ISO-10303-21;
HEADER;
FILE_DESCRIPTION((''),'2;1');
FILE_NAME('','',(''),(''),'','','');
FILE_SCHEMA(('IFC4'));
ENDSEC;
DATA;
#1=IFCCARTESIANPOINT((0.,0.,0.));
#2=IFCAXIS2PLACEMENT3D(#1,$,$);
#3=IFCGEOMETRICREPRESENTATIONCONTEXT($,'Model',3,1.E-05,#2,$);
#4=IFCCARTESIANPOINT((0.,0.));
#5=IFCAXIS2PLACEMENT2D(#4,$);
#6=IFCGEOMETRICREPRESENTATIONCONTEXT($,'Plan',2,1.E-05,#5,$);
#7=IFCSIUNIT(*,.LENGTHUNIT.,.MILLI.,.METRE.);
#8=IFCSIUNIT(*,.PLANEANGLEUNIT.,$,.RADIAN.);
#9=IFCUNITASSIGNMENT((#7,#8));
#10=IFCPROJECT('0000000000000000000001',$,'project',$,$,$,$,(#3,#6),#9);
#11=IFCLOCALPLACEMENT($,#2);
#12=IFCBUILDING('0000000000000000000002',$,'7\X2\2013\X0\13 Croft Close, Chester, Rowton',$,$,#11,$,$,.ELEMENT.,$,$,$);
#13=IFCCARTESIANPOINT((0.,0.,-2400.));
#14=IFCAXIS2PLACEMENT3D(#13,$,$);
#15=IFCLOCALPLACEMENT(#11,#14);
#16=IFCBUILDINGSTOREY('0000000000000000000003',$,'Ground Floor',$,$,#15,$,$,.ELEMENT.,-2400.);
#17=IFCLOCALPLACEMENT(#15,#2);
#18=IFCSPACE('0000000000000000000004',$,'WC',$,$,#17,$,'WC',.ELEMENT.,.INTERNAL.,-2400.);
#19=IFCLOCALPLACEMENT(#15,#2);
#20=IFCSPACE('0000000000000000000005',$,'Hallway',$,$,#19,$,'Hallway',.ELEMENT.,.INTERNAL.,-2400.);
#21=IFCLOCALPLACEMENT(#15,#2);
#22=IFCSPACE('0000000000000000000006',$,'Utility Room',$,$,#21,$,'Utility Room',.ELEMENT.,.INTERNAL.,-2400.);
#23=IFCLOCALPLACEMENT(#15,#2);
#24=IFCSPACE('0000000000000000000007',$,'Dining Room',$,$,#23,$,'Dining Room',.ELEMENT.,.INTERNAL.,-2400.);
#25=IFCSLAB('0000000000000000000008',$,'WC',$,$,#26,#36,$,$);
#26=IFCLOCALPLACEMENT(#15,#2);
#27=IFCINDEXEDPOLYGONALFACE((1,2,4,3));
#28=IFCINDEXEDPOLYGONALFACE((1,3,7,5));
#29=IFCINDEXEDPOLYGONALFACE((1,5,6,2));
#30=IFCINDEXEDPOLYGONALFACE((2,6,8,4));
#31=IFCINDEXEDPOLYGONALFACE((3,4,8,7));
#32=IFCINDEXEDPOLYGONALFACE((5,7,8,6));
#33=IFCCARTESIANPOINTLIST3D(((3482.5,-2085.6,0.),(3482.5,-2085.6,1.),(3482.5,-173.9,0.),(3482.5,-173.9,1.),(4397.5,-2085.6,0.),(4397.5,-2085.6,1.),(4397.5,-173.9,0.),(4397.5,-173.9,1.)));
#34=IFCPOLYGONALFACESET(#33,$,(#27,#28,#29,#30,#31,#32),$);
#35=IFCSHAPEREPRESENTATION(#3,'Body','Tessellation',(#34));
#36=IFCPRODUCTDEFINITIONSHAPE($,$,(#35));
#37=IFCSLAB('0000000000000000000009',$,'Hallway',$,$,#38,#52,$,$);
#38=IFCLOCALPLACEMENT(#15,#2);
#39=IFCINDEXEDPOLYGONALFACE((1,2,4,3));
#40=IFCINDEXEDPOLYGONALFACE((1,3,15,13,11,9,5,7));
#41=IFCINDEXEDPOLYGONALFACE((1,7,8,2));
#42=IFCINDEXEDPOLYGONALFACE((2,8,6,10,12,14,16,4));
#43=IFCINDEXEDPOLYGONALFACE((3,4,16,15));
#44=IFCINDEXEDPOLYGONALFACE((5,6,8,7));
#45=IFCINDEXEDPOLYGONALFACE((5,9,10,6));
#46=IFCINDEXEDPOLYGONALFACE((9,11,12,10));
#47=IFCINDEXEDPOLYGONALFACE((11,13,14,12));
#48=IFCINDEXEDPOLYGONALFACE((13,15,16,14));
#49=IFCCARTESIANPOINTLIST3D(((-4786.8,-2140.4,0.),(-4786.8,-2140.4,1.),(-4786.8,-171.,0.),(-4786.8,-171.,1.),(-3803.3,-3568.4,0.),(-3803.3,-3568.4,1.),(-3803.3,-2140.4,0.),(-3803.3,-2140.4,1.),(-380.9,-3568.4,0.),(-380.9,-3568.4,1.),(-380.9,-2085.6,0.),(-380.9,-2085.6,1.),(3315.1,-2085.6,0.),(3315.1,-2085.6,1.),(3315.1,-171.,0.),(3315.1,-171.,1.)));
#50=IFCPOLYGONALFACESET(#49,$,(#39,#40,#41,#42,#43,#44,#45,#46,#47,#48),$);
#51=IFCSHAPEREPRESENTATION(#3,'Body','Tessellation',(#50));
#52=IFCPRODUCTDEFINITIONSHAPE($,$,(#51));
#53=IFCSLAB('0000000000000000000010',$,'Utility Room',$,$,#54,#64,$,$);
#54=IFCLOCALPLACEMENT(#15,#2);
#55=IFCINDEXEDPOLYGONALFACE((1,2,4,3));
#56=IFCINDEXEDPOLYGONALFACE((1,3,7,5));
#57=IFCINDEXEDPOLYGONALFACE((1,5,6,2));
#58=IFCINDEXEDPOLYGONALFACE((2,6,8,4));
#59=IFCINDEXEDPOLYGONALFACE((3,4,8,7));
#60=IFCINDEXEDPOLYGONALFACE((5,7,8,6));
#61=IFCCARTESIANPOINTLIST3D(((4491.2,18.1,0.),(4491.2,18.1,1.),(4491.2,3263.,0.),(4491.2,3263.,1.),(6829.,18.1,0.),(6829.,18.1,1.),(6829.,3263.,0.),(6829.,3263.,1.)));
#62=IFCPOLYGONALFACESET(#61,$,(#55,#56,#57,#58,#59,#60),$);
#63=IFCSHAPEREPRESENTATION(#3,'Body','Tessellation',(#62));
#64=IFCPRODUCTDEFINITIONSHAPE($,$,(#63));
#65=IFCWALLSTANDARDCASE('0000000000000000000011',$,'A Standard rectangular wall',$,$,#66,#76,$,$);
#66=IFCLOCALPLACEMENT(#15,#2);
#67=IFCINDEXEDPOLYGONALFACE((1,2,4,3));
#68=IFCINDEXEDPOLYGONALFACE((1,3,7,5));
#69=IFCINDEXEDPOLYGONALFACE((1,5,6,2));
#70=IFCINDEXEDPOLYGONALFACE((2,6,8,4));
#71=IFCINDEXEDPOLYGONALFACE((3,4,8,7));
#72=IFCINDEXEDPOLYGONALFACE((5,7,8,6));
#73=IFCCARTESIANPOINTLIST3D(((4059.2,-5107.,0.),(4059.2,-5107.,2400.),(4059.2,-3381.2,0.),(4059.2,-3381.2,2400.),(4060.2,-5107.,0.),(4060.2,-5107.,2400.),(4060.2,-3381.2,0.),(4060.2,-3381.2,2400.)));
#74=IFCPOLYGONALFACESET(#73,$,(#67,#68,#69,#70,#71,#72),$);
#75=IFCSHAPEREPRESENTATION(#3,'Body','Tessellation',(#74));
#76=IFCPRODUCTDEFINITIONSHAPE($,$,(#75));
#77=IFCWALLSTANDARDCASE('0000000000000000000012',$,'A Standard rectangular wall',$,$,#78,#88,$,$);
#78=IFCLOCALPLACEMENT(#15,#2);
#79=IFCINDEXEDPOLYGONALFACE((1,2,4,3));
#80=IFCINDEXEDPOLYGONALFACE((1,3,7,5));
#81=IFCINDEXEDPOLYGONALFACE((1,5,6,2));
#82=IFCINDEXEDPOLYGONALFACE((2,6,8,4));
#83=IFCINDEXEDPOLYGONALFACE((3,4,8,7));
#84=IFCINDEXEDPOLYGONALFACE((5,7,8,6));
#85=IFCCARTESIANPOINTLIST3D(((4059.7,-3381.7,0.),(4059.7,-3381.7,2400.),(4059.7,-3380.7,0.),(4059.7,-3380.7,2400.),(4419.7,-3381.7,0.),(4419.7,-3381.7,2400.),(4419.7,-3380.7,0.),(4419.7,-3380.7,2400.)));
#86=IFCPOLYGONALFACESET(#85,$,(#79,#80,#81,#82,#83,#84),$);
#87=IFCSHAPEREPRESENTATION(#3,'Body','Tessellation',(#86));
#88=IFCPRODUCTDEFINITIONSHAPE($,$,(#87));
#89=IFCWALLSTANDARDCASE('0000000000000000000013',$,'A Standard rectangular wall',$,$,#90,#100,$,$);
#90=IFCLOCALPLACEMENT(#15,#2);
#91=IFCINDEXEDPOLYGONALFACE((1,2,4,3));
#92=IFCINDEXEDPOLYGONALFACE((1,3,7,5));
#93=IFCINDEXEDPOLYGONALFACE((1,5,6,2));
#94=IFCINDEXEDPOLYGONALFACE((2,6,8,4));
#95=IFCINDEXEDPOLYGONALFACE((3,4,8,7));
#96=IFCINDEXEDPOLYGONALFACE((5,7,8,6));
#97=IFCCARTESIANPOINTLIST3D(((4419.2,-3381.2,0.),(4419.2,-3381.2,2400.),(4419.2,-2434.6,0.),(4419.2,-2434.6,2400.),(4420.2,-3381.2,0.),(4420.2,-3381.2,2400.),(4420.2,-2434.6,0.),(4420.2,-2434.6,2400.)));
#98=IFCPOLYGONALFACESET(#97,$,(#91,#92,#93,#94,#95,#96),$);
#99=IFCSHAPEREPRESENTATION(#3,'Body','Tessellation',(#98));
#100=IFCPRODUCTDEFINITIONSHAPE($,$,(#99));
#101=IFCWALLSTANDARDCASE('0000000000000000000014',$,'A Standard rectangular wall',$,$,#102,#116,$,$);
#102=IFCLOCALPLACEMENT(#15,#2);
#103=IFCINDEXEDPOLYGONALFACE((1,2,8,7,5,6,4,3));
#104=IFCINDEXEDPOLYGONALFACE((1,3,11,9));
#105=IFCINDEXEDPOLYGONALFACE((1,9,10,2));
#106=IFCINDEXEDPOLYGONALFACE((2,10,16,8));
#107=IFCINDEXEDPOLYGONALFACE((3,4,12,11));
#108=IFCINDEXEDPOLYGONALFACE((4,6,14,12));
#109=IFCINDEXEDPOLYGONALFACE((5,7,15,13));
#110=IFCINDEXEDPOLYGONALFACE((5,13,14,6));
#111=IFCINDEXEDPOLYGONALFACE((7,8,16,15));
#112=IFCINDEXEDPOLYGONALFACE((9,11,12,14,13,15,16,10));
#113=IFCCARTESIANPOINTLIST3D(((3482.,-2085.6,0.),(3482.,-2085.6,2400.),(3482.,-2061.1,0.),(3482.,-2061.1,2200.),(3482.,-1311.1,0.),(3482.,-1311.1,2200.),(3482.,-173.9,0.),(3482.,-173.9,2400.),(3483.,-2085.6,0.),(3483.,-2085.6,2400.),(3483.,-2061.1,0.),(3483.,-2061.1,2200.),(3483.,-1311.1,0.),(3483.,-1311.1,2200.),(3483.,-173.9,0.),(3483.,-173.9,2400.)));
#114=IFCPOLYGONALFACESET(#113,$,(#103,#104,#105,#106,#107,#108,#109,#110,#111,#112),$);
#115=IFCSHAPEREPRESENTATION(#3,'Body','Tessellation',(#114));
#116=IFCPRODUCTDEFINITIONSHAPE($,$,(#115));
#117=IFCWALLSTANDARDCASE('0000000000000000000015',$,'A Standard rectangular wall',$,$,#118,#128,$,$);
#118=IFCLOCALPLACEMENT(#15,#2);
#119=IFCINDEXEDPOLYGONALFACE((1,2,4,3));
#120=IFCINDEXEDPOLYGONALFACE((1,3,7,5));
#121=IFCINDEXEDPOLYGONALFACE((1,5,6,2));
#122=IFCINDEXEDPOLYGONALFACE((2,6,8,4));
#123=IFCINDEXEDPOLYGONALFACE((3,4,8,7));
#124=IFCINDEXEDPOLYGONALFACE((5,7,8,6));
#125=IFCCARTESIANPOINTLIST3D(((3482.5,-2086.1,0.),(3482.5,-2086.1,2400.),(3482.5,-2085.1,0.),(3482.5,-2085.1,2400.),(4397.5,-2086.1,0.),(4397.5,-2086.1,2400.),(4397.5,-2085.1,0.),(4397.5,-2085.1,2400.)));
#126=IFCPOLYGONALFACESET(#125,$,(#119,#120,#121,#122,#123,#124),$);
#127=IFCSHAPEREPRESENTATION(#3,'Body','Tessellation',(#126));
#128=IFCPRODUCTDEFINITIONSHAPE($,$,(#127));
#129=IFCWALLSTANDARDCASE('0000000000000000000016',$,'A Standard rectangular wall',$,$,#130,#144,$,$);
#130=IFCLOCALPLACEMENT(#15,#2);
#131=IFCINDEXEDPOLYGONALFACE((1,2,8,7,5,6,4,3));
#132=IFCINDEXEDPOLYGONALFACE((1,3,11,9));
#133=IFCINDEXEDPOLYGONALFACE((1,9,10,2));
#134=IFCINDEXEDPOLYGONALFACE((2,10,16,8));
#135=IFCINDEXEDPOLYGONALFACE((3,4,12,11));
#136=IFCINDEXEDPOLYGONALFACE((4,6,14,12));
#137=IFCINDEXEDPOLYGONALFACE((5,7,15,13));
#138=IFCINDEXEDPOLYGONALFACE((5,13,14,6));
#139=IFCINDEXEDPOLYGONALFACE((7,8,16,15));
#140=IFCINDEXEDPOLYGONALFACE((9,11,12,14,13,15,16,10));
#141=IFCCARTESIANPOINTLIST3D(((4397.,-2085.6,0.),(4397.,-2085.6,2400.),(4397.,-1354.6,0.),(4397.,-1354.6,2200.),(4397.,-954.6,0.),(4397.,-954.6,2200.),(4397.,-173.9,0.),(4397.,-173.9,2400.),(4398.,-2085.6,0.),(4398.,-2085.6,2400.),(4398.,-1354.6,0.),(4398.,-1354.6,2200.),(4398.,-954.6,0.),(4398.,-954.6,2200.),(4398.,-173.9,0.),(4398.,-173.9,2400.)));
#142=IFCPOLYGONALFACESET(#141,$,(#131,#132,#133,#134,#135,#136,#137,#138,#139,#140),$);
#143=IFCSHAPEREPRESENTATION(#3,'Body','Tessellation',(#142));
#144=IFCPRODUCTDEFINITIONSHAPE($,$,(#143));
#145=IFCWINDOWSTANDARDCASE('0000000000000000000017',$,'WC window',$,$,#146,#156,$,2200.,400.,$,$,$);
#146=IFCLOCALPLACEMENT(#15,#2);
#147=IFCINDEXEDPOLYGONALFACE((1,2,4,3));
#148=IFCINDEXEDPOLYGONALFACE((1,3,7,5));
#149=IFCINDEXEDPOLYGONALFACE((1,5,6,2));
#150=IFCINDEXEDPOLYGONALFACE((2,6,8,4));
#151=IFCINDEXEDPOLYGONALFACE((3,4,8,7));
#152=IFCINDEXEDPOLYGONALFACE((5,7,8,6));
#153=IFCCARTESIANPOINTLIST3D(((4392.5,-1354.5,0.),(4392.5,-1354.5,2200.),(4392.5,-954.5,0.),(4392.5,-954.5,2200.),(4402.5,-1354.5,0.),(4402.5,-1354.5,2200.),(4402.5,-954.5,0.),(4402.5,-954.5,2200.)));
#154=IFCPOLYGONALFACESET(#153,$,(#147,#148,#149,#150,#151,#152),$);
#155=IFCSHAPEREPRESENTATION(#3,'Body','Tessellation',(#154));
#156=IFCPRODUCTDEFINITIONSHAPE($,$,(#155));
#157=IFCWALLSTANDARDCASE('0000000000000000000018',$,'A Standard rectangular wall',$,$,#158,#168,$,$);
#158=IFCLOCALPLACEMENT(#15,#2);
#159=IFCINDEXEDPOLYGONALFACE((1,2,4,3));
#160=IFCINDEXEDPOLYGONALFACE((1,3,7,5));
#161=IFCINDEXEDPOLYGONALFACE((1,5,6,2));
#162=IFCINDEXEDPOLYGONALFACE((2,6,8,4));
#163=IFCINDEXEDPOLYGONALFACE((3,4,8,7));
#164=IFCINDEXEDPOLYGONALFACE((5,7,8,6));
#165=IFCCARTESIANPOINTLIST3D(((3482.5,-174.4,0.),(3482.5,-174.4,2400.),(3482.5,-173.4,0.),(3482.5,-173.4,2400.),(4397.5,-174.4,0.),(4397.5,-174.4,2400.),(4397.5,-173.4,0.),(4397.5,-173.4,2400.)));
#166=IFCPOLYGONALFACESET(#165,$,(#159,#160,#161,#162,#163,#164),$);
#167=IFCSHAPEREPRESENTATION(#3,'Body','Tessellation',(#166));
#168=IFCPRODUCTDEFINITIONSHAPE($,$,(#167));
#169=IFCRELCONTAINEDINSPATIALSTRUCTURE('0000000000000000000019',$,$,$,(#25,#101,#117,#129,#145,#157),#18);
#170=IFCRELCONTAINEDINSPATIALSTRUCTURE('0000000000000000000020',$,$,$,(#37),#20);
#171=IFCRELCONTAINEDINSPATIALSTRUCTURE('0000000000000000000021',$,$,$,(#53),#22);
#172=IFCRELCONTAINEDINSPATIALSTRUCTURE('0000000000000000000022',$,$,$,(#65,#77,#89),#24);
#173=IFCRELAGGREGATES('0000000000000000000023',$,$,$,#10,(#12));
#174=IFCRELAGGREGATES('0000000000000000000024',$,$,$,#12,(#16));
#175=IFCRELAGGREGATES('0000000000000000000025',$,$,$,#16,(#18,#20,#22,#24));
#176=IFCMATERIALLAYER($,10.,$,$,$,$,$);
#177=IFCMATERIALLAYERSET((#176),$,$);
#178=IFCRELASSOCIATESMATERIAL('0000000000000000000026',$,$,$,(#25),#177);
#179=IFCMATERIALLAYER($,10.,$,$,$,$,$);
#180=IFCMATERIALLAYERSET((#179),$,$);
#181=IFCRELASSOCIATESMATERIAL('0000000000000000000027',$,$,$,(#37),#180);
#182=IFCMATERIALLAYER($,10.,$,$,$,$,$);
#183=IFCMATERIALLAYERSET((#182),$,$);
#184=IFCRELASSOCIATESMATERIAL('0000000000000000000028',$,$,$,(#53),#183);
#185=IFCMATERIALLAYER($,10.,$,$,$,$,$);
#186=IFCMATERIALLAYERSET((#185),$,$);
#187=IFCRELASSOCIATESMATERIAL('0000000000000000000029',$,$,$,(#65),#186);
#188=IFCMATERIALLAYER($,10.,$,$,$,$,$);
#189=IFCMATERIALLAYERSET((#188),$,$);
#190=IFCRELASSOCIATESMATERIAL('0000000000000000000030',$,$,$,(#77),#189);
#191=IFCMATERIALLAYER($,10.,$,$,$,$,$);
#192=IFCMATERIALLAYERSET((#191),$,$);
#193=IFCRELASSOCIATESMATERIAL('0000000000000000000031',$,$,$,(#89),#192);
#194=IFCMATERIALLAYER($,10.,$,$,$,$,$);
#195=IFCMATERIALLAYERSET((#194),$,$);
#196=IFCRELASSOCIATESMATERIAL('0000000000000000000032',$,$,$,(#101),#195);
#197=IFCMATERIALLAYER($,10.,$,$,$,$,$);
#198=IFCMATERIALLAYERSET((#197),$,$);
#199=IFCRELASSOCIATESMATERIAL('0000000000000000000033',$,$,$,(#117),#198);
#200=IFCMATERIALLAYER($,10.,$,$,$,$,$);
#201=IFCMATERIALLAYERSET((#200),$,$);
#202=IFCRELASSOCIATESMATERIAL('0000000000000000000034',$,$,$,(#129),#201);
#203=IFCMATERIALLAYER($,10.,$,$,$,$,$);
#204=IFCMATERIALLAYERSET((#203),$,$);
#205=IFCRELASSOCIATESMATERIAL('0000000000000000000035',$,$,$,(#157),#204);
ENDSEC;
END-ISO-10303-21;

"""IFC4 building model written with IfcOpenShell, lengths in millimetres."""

from ifc_helpers import new_model, si_unit, frame, origin, origin_2d, place, context, project, spatial, polyline, rectangle, outline, extrude, layer, layer_set, layer_usage, element, fill, save


model = new_model("IFC4")

# Units and contexts
model_context = context("Model", 3, precision=1e-05, world=origin())
plan_context = context("Plan", 2, precision=1e-05, world=origin_2d())
ifc_project = project(units=[si_unit("LENGTHUNIT", "METRE", prefix="MILLI"), si_unit("PLANEANGLEUNIT", "RADIAN")], contexts=[model_context, plan_context])

# Building, storey, space
building_placement = place(None, origin())
building = spatial("IfcBuilding", under=ifc_project, at=building_placement, Name="7–13 Croft Close, Chester, Rowton", CompositionType="ELEMENT")
storey_placement = place(building_placement, frame((0.0, 0.0, -2400.0)))
storey = spatial("IfcBuildingStorey", under=building, at=storey_placement, Name="Ground Floor", CompositionType="ELEMENT", Elevation=-2400.0)
space_1_placement = place(storey_placement, origin())
space_1 = spatial("IfcSpace", under=storey, at=space_1_placement, Name="WC", LongName="WC", CompositionType="ELEMENT", PredefinedType="INTERNAL", ElevationWithFlooring=-2400.0)

# Slab
ifc_layer_1 = layer(None, 10.0)
ifc_layer_set_1 = layer_set([ifc_layer_1])
ifc_layer_usage_1 = layer_usage(ifc_layer_set_1, "AXIS2", "NEGATIVE", 150.0)
slab_1_placement = place(storey_placement, origin())
element("IfcSlab", 1, at=slab_1_placement, inside=space_1, material=ifc_layer_usage_1, Name="WC", context=model_context, shape_type="SweptSolid", body=[
    extrude(outline(polyline([(3482.5, -173.9), (3482.5, -2085.6), (4397.5, -2085.6), (4397.5, -173.9), (3482.5, -173.9)])), origin(), (0.0, 0.0, 1.0), 1.0),
])

# Shared definitions
space_2_placement = place(storey_placement, origin())
space_2 = spatial("IfcSpace", under=storey, at=space_2_placement, Name="Hallway", LongName="Hallway", CompositionType="ELEMENT", PredefinedType="INTERNAL", ElevationWithFlooring=-2400.0)

# Slab
ifc_layer_2 = layer(None, 10.0)
ifc_layer_set_2 = layer_set([ifc_layer_2])
ifc_layer_usage_2 = layer_usage(ifc_layer_set_2, "AXIS2", "NEGATIVE", 150.0)
slab_2_placement = place(storey_placement, origin())
element("IfcSlab", 2, at=slab_2_placement, inside=space_2, material=ifc_layer_usage_2, Name="Hallway", context=model_context, shape_type="SweptSolid", body=[
    extrude(outline(polyline([(3315.1, -171.0), (-4786.8, -171.0), (-4786.8, -2140.4), (-3803.3, -2140.4), (-3803.3, -3568.4), (-380.9, -3568.4), (-380.9, -2085.6), (3315.1, -2085.6), (3315.1, -171.0)])), origin(), (0.0, 0.0, 1.0), 1.0),
])

# Shared definitions
space_3_placement = place(storey_placement, origin())
space_3 = spatial("IfcSpace", under=storey, at=space_3_placement, Name="Utility Room", LongName="Utility Room", CompositionType="ELEMENT", PredefinedType="INTERNAL", ElevationWithFlooring=-2400.0)

# Slab
ifc_layer_3 = layer(None, 10.0)
ifc_layer_set_3 = layer_set([ifc_layer_3])
ifc_layer_usage_3 = layer_usage(ifc_layer_set_3, "AXIS2", "NEGATIVE", 150.0)
slab_3_placement = place(storey_placement, origin())
element("IfcSlab", 3, at=slab_3_placement, inside=space_3, material=ifc_layer_usage_3, Name="Utility Room", context=model_context, shape_type="SweptSolid", body=[
    extrude(outline(polyline([(4491.2, 18.1), (6829.0, 18.1), (6829.0, 3263.0), (4491.2, 3263.0), (4491.2, 18.1)])), origin(), (0.0, 0.0, 1.0), 1.0),
])

# Shared definitions
space_4_placement = place(storey_placement, origin())
space_4 = spatial("IfcSpace", under=storey, at=space_4_placement, Name="Dining Room", LongName="Dining Room", CompositionType="ELEMENT", PredefinedType="INTERNAL", ElevationWithFlooring=-2400.0)

# Walls
ifc_layer_4 = layer(None, 10.0)
ifc_layer_set_4 = layer_set([ifc_layer_4])
ifc_layer_usage_4 = layer_usage(ifc_layer_set_4, "AXIS2", "NEGATIVE", 150.0)
wall_1_placement = place(storey_placement, origin())
element("IfcWallStandardCase", 4, at=wall_1_placement, inside=space_4, material=ifc_layer_usage_4, Name="A Standard rectangular wall", context=model_context, shape_type="SweptSolid", body=[
    extrude(rectangle(XDim=1.0, YDim=1725.8, at=origin_2d()), frame((4059.7, -4244.1, 0.0), x_axis=(-1.0, 0.0, 0.0)), (0.0, 0.0, 1.0), 2400.0),
])
ifc_layer_5 = layer(None, 10.0)
ifc_layer_set_5 = layer_set([ifc_layer_5])
ifc_layer_usage_5 = layer_usage(ifc_layer_set_5, "AXIS2", "NEGATIVE", 150.0)
wall_2_placement = place(storey_placement, origin())
element("IfcWallStandardCase", 5, at=wall_2_placement, inside=space_4, material=ifc_layer_usage_5, Name="A Standard rectangular wall", context=model_context, shape_type="SweptSolid", body=[
    extrude(rectangle(XDim=1.0, YDim=360.0, at=origin_2d()), frame((4239.7, -3381.2, 0.0), x_axis=(0.0, 1.0, 0.0)), (0.0, 0.0, 1.0), 2400.0),
])
ifc_layer_6 = layer(None, 10.0)
ifc_layer_set_6 = layer_set([ifc_layer_6])
ifc_layer_usage_6 = layer_usage(ifc_layer_set_6, "AXIS2", "NEGATIVE", 150.0)
wall_3_placement = place(storey_placement, origin())
element("IfcWallStandardCase", 6, at=wall_3_placement, inside=space_4, material=ifc_layer_usage_6, Name="A Standard rectangular wall", context=model_context, shape_type="SweptSolid", body=[
    extrude(rectangle(XDim=1.0, YDim=946.6, at=origin_2d()), frame((4419.7, -2907.9, 0.0), x_axis=(-1.0, 0.0, 0.0)), (0.0, 0.0, 1.0), 2400.0),
])

# Wall, opening
ifc_layer_7 = layer(None, 10.0)
ifc_layer_set_7 = layer_set([ifc_layer_7])
ifc_layer_usage_7 = layer_usage(ifc_layer_set_7, "AXIS2", "NEGATIVE", 150.0)
wall_4_placement = place(storey_placement, origin())
wall_4 = element("IfcWallStandardCase", 7, at=wall_4_placement, inside=space_1, material=ifc_layer_usage_7, Name="A Standard rectangular wall", context=model_context, shape_type="SweptSolid", body=[
    extrude(rectangle(XDim=1.0, YDim=1911.7, at=origin_2d()), frame((3482.5, -1129.7, 0.0), x_axis=(1.0, 0.0, 0.0)), (0.0, 0.0, 1.0), 2400.0),
])
opening_1_placement = place(storey_placement, origin())
element("IfcOpeningElement", 8, at=opening_1_placement, cuts=wall_4, context=model_context, shape_type="SweptSolid", body=[
    extrude(rectangle(XDim=10.0, YDim=750.0, at=origin_2d()), frame((3482.5, -1686.1, 0.0), x_axis=(-1.0, 0.0, 0.0)), (0.0, 0.0, 1.0), 2200.0),
])

# Wall
ifc_layer_8 = layer(None, 10.0)
ifc_layer_set_8 = layer_set([ifc_layer_8])
ifc_layer_usage_8 = layer_usage(ifc_layer_set_8, "AXIS2", "NEGATIVE", 150.0)
wall_5_placement = place(storey_placement, origin())
element("IfcWallStandardCase", 9, at=wall_5_placement, inside=space_1, material=ifc_layer_usage_8, Name="A Standard rectangular wall", context=model_context, shape_type="SweptSolid", body=[
    extrude(rectangle(XDim=1.0, YDim=915.0, at=origin_2d()), frame((3940.0, -2085.6, 0.0), x_axis=(0.0, 1.0, 0.0)), (0.0, 0.0, 1.0), 2400.0),
])

# Wall, opening, window
ifc_layer_9 = layer(None, 10.0)
ifc_layer_set_9 = layer_set([ifc_layer_9])
ifc_layer_usage_9 = layer_usage(ifc_layer_set_9, "AXIS2", "NEGATIVE", 150.0)
wall_6_placement = place(storey_placement, origin())
wall_6 = element("IfcWallStandardCase", 10, at=wall_6_placement, inside=space_1, material=ifc_layer_usage_9, Name="A Standard rectangular wall", context=model_context, shape_type="SweptSolid", body=[
    extrude(rectangle(XDim=1.0, YDim=1911.7, at=origin_2d()), frame((4397.5, -1129.7, 0.0), x_axis=(-1.0, 0.0, 0.0)), (0.0, 0.0, 1.0), 2400.0),
])
opening_2_placement = place(storey_placement, origin())
opening_2 = element("IfcOpeningElement", 11, at=opening_2_placement, cuts=wall_6, context=model_context, shape_type="SweptSolid", body=[
    extrude(rectangle(XDim=10.0, YDim=400.0, at=origin_2d()), frame((4397.5, -1154.6, 0.0), x_axis=(-1.0, 0.0, 0.0)), (0.0, 0.0, 1.0), 2200.0),
])
window_1_placement = place(storey_placement, frame((0.0, 0.1, 0.0)))
window_1 = element("IfcWindowStandardCase", 12, at=window_1_placement, inside=space_1, Name="WC window", OverallHeight=2200.0, OverallWidth=400.0, context=model_context, shape_type="SweptSolid", body=[
    extrude(rectangle(XDim=10.0, YDim=400.0, at=origin_2d()), frame((4397.5, -1154.6, 0.0), x_axis=(-1.0, 0.0, 0.0)), (0.0, 0.0, 1.0), 2200.0),
])
fill(opening_2, window_1)

# Wall
ifc_layer_10 = layer(None, 10.0)
ifc_layer_set_10 = layer_set([ifc_layer_10])
ifc_layer_usage_10 = layer_usage(ifc_layer_set_10, "AXIS2", "NEGATIVE", 150.0)
wall_7_placement = place(storey_placement, origin())
element("IfcWallStandardCase", 13, at=wall_7_placement, inside=space_1, material=ifc_layer_usage_10, Name="A Standard rectangular wall", context=model_context, shape_type="SweptSolid", body=[
    extrude(rectangle(XDim=1.0, YDim=915.0, at=origin_2d()), frame((3940.0, -173.9, 0.0), x_axis=(0.0, -1.0, 0.0)), (0.0, 0.0, 1.0), 2400.0),
])

save(model, "model.ifc")
